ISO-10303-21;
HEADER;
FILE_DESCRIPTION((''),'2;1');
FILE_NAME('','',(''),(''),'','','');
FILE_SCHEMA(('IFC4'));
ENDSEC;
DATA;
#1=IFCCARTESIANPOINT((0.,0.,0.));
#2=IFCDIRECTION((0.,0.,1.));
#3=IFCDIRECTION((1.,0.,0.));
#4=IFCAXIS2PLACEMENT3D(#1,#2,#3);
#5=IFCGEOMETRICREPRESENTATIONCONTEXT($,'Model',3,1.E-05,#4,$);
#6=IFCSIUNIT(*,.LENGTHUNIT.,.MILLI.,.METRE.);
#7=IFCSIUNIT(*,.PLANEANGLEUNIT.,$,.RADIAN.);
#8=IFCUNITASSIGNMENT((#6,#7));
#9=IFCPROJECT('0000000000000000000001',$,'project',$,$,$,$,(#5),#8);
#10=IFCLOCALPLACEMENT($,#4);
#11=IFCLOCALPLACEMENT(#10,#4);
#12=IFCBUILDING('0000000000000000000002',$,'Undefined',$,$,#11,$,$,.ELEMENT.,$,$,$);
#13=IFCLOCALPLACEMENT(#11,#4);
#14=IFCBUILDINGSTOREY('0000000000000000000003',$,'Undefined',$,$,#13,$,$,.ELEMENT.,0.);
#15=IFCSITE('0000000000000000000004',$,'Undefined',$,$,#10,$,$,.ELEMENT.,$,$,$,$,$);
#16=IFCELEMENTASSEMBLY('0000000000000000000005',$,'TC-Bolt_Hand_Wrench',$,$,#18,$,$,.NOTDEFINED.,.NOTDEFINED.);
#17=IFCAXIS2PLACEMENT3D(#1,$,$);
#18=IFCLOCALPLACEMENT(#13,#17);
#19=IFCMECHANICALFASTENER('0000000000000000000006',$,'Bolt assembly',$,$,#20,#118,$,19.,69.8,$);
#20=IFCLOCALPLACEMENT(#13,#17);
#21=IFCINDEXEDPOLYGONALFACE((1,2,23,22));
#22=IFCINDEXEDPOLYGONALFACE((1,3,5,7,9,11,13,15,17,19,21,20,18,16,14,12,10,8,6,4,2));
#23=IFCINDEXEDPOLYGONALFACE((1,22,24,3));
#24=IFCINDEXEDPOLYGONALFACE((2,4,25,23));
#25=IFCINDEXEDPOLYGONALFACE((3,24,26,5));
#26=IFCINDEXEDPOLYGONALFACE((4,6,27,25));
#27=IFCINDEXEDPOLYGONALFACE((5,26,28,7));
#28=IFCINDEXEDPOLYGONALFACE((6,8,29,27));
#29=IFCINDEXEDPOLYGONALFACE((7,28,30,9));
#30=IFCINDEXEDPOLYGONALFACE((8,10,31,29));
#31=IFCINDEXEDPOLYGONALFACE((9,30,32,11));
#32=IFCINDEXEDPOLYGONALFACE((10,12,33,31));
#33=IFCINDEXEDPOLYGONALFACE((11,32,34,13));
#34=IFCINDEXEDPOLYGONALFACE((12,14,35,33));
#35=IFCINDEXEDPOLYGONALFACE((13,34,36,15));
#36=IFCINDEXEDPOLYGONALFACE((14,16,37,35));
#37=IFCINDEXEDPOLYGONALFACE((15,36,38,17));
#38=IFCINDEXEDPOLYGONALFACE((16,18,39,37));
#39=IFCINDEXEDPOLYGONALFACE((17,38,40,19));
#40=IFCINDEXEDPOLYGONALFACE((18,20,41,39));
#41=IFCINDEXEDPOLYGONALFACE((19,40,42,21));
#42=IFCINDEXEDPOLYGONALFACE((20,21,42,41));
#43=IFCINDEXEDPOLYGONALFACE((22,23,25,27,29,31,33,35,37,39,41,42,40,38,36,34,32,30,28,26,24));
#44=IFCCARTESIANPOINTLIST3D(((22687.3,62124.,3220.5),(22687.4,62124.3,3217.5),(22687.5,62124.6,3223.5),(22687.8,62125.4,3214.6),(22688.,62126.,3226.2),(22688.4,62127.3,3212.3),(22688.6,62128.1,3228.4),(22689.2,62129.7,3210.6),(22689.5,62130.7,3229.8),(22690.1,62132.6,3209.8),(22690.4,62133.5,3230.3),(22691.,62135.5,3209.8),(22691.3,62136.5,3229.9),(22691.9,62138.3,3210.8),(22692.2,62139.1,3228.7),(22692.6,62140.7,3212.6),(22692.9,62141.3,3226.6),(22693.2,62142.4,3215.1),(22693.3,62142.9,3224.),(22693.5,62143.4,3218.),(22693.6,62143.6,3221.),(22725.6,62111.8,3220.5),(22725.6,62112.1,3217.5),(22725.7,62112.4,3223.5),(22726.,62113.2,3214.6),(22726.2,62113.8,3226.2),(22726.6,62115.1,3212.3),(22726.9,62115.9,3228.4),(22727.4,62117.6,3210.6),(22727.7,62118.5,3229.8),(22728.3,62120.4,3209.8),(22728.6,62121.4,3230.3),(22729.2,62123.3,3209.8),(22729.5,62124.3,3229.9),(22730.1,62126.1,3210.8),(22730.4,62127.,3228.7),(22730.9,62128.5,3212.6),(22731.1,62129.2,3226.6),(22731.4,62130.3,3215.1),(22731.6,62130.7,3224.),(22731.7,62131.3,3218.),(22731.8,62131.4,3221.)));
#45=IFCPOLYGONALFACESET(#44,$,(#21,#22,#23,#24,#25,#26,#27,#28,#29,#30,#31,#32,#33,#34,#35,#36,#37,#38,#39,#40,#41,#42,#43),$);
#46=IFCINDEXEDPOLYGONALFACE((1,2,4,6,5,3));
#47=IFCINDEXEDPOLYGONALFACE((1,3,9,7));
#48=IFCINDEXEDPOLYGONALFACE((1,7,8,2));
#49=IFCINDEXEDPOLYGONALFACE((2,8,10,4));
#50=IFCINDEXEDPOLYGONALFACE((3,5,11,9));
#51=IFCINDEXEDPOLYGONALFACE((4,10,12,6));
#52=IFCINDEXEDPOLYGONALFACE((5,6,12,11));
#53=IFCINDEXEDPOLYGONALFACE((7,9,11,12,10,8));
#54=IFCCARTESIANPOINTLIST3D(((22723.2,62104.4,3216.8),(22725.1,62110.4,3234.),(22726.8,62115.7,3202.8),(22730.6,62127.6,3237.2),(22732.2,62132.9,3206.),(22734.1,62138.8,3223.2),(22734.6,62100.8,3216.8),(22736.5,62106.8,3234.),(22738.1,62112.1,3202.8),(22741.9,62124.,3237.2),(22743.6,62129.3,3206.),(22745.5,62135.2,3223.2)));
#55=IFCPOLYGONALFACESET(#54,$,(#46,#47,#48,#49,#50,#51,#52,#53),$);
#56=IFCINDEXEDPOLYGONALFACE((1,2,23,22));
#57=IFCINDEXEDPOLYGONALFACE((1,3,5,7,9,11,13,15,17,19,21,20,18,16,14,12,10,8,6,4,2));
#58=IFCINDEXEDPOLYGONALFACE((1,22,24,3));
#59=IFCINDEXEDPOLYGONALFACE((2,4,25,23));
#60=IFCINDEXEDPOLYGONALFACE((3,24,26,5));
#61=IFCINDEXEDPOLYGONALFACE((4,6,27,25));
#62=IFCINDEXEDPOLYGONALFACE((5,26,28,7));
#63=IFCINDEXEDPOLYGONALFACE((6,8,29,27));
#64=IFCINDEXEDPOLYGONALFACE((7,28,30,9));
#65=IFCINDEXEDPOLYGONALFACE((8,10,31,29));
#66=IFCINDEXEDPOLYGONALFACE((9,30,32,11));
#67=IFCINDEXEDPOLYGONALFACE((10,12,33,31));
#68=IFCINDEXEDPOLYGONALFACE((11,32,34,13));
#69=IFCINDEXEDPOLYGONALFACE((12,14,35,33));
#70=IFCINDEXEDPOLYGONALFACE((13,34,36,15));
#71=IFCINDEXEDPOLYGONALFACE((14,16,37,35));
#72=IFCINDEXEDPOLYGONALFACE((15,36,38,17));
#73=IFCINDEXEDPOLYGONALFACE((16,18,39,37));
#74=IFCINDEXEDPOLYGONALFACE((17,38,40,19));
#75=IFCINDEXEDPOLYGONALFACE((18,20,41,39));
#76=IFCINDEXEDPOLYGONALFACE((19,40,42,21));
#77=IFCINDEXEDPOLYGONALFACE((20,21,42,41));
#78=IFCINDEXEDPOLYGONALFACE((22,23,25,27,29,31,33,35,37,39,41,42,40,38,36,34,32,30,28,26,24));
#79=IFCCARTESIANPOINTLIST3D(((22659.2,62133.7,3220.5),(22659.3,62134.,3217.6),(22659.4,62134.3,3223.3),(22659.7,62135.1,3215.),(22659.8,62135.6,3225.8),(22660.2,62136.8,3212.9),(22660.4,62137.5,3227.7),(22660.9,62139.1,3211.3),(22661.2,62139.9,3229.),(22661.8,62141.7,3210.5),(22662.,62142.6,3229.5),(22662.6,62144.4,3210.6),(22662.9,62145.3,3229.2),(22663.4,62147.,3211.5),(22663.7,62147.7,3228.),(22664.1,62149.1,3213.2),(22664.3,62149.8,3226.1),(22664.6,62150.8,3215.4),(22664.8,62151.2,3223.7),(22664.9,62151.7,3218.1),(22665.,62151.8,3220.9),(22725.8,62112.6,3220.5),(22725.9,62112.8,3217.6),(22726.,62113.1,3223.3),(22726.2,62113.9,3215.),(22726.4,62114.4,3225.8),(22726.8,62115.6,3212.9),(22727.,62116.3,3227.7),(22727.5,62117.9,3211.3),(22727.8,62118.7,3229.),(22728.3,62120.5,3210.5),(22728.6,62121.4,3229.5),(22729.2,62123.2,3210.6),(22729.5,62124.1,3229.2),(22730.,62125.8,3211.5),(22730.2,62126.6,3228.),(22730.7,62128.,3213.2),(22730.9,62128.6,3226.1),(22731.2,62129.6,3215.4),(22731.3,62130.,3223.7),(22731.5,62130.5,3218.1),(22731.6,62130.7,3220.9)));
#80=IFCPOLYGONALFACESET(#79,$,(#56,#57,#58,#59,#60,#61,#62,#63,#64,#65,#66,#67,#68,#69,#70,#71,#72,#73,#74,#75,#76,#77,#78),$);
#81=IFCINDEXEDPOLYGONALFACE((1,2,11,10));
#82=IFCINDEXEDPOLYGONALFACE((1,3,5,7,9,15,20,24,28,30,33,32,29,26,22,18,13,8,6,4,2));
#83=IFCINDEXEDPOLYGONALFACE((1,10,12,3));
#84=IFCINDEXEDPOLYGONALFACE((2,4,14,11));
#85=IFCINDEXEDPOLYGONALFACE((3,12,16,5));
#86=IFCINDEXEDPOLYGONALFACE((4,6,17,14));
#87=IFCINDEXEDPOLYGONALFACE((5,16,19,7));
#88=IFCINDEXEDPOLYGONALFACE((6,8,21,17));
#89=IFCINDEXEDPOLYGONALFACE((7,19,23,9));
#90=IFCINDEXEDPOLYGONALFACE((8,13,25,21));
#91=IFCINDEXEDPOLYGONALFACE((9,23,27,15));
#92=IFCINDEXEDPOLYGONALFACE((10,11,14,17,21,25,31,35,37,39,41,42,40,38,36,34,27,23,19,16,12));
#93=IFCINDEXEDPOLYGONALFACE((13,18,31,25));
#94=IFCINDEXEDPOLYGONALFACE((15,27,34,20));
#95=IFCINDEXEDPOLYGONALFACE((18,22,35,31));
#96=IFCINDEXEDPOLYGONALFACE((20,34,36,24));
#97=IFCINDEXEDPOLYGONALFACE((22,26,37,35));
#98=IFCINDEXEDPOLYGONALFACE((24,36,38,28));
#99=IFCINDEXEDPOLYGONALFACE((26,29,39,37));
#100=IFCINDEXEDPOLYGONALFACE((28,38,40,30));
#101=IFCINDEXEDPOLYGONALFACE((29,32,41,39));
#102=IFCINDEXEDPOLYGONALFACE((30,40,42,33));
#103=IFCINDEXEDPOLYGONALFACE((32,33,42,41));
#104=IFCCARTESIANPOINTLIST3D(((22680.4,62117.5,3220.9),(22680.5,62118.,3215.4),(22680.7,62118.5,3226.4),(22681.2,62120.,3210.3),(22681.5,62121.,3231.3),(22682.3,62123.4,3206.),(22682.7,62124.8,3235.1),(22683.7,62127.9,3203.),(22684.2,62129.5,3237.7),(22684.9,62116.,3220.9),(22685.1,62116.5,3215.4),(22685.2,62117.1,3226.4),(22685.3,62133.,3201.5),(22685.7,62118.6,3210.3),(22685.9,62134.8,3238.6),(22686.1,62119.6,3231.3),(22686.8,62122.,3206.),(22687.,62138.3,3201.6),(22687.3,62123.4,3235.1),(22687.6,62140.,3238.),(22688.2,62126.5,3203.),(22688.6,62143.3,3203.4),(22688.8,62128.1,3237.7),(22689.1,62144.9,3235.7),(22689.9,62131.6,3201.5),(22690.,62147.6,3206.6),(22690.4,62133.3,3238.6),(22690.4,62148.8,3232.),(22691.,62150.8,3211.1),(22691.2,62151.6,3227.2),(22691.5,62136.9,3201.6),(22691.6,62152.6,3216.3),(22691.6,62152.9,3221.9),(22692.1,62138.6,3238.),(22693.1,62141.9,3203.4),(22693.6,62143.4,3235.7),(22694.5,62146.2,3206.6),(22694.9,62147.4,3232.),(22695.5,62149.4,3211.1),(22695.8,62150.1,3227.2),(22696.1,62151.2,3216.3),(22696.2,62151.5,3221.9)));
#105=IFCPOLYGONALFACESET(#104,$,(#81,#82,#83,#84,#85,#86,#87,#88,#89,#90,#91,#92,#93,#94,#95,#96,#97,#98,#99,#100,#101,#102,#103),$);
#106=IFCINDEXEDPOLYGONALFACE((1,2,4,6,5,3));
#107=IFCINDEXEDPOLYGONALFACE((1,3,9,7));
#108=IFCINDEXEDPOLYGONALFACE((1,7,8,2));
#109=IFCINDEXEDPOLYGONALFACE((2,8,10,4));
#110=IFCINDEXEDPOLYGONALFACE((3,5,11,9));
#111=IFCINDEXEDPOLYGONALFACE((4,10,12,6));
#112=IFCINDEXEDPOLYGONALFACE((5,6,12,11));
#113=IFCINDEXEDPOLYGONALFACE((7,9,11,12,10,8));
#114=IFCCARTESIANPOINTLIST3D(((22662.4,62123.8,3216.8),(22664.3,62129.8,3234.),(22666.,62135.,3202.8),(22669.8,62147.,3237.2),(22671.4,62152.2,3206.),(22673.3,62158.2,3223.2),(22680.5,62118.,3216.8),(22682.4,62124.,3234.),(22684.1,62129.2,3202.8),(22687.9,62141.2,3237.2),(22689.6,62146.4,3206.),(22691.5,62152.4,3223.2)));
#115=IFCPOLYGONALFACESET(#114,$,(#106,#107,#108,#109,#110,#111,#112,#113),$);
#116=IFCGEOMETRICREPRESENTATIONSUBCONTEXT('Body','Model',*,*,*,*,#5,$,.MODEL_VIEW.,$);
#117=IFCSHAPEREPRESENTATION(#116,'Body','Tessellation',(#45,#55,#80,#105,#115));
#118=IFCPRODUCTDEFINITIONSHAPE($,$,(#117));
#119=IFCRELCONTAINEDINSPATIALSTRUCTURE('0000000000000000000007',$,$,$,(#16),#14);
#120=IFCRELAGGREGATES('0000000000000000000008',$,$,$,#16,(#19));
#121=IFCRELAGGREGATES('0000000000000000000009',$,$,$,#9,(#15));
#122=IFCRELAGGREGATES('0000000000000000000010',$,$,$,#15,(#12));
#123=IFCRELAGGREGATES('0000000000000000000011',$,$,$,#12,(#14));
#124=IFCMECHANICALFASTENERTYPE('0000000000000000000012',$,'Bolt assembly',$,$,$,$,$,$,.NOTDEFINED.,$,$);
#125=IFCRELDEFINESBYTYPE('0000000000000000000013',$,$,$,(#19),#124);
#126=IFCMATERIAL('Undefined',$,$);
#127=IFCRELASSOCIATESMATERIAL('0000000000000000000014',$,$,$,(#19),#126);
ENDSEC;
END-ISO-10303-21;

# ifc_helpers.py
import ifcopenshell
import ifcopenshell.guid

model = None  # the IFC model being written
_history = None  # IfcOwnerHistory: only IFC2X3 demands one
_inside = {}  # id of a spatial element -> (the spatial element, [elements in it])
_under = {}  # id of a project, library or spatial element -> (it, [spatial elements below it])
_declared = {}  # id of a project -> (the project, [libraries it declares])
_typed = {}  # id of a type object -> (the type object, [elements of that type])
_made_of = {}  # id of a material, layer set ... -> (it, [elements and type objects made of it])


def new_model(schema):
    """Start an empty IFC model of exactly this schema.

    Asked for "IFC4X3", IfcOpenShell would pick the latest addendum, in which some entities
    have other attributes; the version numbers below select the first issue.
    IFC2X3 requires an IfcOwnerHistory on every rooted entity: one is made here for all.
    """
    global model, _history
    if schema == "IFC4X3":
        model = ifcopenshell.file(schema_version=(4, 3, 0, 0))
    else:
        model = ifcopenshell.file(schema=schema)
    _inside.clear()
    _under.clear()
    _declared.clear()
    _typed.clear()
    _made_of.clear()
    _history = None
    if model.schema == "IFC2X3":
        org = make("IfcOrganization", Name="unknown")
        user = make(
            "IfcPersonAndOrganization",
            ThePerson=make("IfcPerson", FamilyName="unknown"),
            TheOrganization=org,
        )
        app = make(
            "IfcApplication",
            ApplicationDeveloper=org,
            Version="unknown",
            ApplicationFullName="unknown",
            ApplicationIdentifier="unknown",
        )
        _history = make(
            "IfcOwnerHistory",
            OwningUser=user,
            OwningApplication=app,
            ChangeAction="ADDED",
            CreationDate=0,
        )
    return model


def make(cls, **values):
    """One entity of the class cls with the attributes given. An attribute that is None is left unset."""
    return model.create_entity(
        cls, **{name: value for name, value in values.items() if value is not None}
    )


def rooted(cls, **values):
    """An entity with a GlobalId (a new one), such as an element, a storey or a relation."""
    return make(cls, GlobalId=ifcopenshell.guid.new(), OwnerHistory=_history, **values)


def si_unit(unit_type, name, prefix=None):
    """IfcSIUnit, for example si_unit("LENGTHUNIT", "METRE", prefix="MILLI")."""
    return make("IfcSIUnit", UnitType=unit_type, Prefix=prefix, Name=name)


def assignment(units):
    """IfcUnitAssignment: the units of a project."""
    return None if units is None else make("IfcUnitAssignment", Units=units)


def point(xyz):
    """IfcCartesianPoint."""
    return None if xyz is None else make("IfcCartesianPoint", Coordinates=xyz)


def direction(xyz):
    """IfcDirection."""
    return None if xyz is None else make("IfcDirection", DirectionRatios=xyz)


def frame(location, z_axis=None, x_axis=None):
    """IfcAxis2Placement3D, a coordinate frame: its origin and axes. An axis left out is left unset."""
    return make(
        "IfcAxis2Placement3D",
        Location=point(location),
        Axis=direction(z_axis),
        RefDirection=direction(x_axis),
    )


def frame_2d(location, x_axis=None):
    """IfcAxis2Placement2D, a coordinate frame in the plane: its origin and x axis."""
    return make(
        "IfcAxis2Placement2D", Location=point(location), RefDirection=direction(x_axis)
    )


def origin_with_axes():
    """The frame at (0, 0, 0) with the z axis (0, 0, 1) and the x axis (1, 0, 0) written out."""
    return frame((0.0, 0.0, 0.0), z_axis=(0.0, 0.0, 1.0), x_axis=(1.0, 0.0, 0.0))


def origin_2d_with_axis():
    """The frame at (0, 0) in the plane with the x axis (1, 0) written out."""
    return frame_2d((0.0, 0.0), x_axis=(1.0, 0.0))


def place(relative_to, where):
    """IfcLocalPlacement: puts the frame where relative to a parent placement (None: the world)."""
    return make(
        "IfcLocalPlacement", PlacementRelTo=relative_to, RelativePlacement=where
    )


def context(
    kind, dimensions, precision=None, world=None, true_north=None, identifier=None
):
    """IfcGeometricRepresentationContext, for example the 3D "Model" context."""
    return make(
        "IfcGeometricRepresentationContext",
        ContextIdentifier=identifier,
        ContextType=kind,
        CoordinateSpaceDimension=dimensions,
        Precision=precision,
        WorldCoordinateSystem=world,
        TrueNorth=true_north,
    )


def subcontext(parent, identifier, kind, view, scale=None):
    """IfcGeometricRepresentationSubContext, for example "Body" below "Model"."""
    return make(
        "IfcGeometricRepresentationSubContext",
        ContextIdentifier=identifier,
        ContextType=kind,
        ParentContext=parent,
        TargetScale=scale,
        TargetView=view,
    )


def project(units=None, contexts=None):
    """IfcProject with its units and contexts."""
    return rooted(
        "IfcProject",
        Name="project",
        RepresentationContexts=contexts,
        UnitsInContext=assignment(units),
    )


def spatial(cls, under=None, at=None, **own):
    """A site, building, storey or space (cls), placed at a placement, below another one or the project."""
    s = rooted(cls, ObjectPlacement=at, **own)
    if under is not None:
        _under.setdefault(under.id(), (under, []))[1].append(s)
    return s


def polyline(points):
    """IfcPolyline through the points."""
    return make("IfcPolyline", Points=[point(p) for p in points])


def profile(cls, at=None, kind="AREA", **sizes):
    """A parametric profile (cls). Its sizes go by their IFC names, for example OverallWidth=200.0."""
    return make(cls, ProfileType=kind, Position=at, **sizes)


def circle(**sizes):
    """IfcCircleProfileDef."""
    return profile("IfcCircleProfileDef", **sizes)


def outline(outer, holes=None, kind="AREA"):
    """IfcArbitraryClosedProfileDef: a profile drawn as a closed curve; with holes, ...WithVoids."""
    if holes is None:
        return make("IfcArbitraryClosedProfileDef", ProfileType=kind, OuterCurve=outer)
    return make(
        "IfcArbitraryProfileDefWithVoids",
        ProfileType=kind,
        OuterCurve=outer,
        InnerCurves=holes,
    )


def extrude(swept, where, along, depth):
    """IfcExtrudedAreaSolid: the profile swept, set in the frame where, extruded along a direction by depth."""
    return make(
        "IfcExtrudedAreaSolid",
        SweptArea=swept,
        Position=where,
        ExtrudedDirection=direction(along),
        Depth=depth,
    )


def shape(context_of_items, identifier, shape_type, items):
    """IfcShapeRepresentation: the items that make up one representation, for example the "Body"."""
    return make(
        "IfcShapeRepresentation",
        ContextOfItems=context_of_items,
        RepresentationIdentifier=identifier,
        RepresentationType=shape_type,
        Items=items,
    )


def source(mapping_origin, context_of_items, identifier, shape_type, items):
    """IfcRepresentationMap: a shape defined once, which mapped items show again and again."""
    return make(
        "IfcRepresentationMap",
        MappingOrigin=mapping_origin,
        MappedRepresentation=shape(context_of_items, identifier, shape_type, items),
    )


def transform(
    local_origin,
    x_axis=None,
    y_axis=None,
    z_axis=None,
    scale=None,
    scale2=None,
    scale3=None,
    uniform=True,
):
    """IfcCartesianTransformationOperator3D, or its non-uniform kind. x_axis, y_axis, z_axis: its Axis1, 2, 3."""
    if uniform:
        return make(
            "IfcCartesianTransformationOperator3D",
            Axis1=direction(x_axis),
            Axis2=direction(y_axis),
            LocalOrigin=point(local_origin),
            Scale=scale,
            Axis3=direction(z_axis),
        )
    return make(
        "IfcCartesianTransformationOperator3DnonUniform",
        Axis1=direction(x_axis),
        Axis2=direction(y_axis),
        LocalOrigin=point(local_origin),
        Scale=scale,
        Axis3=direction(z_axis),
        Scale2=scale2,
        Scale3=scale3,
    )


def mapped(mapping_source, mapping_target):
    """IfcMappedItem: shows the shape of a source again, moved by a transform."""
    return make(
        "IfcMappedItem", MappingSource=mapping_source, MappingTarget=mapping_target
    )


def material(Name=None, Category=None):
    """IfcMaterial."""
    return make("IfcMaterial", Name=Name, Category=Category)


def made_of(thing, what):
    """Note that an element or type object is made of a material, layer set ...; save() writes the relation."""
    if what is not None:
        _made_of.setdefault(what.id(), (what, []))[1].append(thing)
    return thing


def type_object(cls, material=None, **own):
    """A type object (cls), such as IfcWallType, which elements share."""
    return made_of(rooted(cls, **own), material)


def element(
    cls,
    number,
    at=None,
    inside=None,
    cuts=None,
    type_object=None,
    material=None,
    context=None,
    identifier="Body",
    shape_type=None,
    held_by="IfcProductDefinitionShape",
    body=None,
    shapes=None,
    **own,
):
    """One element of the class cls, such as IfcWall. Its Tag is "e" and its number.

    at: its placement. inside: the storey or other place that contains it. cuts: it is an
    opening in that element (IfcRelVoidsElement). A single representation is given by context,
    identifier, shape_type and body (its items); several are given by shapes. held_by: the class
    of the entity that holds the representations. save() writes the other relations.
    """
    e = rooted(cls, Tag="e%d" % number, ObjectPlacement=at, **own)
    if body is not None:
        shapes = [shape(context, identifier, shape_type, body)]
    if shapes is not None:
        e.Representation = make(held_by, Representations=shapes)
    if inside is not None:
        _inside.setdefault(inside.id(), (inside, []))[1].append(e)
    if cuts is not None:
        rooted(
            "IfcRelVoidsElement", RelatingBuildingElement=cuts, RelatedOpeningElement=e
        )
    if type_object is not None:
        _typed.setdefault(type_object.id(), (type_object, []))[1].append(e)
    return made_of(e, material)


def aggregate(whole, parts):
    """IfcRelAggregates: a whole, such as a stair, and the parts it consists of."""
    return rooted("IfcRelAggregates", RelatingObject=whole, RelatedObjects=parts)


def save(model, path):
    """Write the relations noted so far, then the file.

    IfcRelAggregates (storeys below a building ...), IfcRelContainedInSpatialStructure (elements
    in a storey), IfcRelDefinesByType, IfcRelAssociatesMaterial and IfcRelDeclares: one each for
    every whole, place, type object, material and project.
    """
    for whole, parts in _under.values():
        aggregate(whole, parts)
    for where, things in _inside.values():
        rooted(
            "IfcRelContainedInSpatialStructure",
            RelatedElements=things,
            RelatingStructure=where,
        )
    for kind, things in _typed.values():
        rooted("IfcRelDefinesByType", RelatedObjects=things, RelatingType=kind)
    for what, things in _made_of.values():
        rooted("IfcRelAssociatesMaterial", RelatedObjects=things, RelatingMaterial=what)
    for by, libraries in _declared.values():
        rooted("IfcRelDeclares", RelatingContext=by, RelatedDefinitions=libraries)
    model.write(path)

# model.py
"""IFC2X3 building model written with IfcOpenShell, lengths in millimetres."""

from ifc_helpers import new_model, si_unit, frame, origin_with_axes, origin_2d_with_axis, place, context, subcontext, project, spatial, polyline, circle, outline, extrude, source, transform, mapped, material, type_object, element, aggregate, save


model = new_model("IFC2X3")

# Units and contexts
model_context = context("Model", 3, precision=1e-05, world=origin_with_axes())
body_context = subcontext(model_context, "Body", "Model", "MODEL_VIEW")
ifc_project = project(units=[si_unit("LENGTHUNIT", "METRE", prefix="MILLI"), si_unit("PLANEANGLEUNIT", "RADIAN")], contexts=[model_context])

# Site, building, storey
site_placement = place(None, origin_with_axes())
site = spatial("IfcSite", under=ifc_project, at=site_placement, Name="Undefined", CompositionType="ELEMENT")
building_placement = place(site_placement, origin_with_axes())
building = spatial("IfcBuilding", under=site, at=building_placement, Name="Undefined", CompositionType="ELEMENT")
storey_placement = place(building_placement, origin_with_axes())
storey = spatial("IfcBuildingStorey", under=building, at=storey_placement, Name="Undefined", CompositionType="ELEMENT", Elevation=0.0)

# Shared definitions
ifc_material_1 = material(Name="Undefined")
mechanical_fastener_type = type_object("IfcMechanicalFastenerType", Name="Bolt assembly")

# Element assembly, mechanical fastener
assembly_1_placement = place(storey_placement, origin_with_axes())
assembly_1 = element("IfcElementAssembly", 1, at=assembly_1_placement, inside=storey, Name="TC-Bolt_Hand_Wrench", AssemblyPlace="NOTDEFINED", PredefinedType="NOTDEFINED")
shared_shape_1 = source(origin_with_axes(), body_context, "Body", "SweptSolid", [
    extrude(circle(Radius=10.3, at=origin_2d_with_axis()), frame((0.0, -40.0, 0.0), z_axis=(0.0, 1.0, 0.0), x_axis=(1.0, 0.0, 0.0)), (0.0, 0.0, 1.0), 40.1),
    extrude(outline(polyline([(15.9, -9.2), (15.9, 9.2), (0.0, 18.3), (-15.9, 9.2), (-15.9, -9.2), (0.0, -18.3), (15.9, -9.2)])), frame((0.0, -51.9, 0.0), z_axis=(0.0, 1.0, 0.0), x_axis=(1.0, 0.0, 0.0)), (0.0, 0.0, 1.0), 11.9),
    extrude(circle(Radius=9.5, at=origin_2d_with_axis()), frame((0.0, -40.0, 0.0), z_axis=(0.0, 1.0, 0.0), x_axis=(1.0, 0.0, 0.0)), (0.0, 0.0, 1.0), 69.8),
    extrude(circle(Radius=18.7, at=origin_2d_with_axis()), frame((0.0, 0.0, 0.0), z_axis=(0.0, 1.0, 0.0), x_axis=(1.0, 0.0, 0.0)), (0.0, 0.0, 1.0), 4.8),
    extrude(outline(polyline([(15.9, -9.2), (15.9, 9.2), (0.0, 18.3), (-15.9, 9.2), (-15.9, -9.2), (0.0, -18.3), (15.9, -9.2)])), frame((0.0, 4.8, 0.0), z_axis=(0.0, 1.0, 0.0), x_axis=(1.0, 0.0, 0.0)), (0.0, 0.0, 1.0), 19.1),
])
mechanical_fastener_1_placement = place(assembly_1_placement, frame((22690.6, 62133.8, 3220.0), z_axis=(-0.194835, -0.612548, 0.766044), x_axis=(0.232195, 0.730006, 0.642788)))
mechanical_fastener_1 = element("IfcMechanicalFastener", 2, at=mechanical_fastener_1_placement, type_object=mechanical_fastener_type, material=ifc_material_1, Name="Bolt assembly", NominalDiameter=19.0, NominalLength=69.8, context=body_context, shape_type="MappedRepresentation", body=[
    mapped(shared_shape_1, transform((0.0, 0.0, 0.0))),
])
aggregate(assembly_1, [mechanical_fastener_1])

save(model, "model.ifc")
